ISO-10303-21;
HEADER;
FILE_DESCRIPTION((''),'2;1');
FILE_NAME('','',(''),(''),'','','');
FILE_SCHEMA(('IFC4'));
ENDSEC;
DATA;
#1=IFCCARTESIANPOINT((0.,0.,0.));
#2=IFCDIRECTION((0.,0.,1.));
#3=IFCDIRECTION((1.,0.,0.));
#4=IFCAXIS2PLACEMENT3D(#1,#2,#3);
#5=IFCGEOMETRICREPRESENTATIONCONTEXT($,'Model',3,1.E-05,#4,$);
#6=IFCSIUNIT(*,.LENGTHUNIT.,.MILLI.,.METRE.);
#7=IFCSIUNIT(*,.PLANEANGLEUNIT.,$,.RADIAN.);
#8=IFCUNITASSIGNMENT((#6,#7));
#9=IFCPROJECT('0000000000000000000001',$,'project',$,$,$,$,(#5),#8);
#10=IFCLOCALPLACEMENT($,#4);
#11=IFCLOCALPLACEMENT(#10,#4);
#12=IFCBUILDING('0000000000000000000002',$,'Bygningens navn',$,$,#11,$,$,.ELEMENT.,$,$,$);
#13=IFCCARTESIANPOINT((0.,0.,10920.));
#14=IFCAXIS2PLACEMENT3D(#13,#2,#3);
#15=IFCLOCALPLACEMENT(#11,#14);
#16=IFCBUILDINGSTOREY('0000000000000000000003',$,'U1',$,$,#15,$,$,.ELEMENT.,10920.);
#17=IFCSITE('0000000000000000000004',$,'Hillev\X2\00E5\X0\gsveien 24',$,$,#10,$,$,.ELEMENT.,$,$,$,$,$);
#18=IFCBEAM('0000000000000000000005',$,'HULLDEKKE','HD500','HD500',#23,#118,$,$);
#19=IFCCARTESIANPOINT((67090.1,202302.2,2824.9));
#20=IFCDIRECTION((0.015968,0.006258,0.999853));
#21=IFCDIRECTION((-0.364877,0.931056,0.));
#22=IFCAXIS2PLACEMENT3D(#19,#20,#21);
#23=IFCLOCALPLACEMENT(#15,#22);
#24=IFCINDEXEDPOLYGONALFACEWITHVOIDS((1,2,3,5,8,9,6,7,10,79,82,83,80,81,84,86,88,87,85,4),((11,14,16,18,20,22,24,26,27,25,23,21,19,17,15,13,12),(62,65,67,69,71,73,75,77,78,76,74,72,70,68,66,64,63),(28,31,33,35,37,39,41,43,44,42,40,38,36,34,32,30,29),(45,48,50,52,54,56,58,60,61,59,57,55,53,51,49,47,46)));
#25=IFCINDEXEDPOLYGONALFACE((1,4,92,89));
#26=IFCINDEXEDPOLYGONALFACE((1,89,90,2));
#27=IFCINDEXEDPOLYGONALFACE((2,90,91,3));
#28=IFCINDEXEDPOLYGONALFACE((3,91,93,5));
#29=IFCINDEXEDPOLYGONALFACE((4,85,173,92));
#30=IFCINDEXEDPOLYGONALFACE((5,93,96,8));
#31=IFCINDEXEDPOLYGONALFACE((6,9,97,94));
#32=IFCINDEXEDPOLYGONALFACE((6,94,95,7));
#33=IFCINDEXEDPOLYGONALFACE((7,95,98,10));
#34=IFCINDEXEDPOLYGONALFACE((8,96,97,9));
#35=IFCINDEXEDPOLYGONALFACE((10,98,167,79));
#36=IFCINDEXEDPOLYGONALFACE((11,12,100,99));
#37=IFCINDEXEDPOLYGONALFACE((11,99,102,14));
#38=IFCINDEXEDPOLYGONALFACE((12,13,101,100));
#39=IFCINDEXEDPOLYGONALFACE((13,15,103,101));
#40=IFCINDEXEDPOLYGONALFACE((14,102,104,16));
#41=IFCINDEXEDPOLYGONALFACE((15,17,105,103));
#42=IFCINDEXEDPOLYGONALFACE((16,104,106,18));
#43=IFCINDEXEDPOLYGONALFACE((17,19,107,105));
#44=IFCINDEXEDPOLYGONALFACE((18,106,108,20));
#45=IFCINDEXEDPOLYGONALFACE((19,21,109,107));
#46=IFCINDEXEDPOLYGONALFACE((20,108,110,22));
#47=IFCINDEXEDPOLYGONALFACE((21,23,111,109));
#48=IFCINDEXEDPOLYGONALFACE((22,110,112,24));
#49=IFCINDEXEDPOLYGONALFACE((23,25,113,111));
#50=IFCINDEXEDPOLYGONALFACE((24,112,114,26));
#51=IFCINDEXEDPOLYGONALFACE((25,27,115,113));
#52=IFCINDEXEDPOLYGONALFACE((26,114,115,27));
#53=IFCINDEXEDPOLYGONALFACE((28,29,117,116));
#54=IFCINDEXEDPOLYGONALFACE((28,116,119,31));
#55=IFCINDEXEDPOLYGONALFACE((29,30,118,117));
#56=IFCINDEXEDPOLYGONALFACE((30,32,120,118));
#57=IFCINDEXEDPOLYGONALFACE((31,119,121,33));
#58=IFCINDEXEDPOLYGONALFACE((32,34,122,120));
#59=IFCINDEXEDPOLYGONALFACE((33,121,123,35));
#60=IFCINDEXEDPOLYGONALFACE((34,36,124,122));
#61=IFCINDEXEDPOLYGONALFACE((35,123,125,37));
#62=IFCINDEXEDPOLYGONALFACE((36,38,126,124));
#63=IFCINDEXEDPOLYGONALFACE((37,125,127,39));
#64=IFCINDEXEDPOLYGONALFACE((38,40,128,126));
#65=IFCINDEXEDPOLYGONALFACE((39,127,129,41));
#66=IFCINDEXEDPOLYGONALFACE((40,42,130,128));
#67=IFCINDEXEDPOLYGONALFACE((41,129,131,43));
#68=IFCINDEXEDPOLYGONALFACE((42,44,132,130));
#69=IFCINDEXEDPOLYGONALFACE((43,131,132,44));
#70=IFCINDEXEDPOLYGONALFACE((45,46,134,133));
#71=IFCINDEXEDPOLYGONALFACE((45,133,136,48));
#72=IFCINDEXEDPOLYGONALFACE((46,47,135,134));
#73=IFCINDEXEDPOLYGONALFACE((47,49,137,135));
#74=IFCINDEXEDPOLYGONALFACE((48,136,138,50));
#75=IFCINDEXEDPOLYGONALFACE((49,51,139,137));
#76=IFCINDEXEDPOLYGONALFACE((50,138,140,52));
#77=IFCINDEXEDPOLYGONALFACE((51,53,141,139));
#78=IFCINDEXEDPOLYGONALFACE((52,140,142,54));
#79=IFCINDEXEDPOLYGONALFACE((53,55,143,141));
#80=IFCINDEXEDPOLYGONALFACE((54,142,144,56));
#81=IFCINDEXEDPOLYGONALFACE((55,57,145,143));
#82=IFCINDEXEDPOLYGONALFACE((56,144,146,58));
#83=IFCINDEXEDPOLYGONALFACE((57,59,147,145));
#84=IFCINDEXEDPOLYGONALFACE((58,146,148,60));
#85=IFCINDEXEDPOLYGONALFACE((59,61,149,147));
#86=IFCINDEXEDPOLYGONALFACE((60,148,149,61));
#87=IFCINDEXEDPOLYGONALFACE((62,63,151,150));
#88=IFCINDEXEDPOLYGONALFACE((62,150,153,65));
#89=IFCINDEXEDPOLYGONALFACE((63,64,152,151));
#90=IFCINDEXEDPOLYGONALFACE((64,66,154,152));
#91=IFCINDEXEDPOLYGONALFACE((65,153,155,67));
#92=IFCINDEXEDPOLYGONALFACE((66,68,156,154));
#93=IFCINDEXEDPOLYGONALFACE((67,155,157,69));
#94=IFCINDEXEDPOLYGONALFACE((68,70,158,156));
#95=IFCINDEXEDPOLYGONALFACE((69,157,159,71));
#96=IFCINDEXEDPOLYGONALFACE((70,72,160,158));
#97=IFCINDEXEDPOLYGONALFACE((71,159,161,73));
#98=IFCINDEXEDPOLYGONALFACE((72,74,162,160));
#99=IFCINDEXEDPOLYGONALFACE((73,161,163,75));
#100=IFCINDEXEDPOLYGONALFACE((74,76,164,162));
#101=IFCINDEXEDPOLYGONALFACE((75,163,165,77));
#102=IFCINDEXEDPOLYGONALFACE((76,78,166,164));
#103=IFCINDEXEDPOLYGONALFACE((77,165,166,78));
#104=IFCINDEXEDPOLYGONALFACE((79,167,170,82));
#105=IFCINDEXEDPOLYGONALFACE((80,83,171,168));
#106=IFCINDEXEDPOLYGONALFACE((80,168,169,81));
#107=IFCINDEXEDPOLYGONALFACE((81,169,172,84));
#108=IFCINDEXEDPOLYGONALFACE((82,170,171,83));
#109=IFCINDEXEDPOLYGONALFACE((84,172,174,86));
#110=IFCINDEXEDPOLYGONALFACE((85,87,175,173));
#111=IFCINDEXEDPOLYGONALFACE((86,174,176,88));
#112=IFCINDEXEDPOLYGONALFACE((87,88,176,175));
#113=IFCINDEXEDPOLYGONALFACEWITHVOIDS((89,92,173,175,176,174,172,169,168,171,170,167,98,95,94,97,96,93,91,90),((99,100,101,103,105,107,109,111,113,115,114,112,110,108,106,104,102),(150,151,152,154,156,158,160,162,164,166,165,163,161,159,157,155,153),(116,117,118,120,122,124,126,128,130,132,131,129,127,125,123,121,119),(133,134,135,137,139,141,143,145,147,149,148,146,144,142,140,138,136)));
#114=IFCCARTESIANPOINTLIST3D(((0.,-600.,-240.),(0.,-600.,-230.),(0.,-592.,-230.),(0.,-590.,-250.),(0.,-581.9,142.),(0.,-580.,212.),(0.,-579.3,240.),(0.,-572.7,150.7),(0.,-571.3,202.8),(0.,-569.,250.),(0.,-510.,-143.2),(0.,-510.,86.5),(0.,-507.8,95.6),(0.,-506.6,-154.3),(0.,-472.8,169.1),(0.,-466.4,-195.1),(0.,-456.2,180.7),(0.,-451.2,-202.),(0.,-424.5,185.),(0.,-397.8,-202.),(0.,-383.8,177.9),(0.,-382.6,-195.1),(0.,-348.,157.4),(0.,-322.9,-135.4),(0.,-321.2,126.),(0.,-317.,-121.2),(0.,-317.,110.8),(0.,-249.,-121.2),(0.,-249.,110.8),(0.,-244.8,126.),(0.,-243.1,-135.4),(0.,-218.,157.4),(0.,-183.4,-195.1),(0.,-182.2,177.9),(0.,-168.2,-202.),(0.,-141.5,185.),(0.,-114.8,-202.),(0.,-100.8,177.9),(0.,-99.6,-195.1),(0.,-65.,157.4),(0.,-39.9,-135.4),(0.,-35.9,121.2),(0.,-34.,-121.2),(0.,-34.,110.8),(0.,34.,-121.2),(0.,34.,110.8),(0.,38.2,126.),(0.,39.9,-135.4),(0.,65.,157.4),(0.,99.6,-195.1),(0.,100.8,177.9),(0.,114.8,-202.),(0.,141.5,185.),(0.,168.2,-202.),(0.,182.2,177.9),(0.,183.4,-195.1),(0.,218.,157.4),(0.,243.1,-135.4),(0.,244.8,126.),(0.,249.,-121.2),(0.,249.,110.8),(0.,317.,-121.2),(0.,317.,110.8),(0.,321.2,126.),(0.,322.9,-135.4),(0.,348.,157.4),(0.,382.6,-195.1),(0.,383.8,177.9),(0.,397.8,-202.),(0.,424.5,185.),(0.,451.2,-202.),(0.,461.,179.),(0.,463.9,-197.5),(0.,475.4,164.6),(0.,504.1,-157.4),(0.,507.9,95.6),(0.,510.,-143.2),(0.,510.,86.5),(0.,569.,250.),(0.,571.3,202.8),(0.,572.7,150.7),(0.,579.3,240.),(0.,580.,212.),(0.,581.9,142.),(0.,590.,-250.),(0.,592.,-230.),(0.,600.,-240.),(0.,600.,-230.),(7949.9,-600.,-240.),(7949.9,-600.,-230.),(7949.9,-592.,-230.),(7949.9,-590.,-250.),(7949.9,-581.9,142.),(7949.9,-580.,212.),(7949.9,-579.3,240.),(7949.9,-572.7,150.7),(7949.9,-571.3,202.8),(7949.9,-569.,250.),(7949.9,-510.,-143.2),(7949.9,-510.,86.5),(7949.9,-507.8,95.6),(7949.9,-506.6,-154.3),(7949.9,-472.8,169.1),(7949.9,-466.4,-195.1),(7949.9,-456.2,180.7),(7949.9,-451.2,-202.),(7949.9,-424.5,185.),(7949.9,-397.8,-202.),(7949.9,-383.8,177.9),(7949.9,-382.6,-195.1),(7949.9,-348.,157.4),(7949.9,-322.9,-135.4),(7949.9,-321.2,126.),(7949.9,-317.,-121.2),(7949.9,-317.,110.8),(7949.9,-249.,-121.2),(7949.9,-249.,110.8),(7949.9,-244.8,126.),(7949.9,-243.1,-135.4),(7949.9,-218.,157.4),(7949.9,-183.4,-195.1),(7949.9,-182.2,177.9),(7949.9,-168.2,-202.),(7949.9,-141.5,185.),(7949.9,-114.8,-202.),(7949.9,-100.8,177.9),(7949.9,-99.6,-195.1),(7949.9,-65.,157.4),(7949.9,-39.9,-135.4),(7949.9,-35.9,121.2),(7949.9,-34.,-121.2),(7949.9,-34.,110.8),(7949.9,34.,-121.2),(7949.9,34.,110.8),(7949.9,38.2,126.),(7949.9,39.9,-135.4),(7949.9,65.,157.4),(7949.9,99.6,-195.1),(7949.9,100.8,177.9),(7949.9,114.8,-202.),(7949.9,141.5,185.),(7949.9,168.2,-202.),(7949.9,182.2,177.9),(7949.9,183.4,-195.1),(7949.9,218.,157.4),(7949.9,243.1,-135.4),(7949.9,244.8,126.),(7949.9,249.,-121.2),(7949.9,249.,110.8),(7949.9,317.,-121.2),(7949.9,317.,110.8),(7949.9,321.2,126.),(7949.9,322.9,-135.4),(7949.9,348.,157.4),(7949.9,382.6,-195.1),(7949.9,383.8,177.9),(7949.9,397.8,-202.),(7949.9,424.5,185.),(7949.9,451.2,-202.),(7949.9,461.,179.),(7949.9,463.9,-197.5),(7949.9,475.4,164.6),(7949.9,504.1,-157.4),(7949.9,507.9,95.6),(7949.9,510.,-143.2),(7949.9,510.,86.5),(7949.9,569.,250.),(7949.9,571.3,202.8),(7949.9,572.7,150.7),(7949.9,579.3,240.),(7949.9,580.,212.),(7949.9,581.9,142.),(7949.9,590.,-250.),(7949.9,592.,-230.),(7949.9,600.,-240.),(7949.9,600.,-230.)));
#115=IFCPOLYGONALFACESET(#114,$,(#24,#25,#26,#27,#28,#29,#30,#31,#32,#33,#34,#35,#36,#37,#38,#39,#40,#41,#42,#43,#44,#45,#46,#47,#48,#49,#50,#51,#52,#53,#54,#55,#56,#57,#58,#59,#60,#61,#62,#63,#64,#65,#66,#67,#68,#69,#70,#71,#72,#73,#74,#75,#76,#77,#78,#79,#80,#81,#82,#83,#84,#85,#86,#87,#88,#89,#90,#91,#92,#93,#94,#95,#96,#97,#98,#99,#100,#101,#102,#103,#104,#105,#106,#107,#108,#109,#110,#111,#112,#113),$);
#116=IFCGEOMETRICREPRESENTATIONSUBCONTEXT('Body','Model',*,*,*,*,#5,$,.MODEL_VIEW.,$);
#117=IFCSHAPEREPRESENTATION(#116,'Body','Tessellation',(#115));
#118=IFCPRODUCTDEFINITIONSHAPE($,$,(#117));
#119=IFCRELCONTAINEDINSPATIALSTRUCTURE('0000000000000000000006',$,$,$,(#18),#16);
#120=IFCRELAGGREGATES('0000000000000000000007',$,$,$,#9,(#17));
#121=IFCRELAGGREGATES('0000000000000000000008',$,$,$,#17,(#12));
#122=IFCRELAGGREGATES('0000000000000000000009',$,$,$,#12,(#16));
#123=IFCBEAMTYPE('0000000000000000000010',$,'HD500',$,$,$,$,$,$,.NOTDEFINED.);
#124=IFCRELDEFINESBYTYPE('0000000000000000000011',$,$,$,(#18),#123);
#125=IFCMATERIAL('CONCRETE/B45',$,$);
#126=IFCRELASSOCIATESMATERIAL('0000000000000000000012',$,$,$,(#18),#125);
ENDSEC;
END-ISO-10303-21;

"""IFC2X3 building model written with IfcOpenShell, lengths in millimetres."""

from ifc_helpers import new_model, si_unit, frame, origin_with_axes, place, context, subcontext, project, spatial, polyline, outline, extrude, material, type_object, element, save


model = new_model("IFC2X3")

# Units and contexts
model_context = context("Model", 3, precision=1e-05, world=origin_with_axes())
body_context = subcontext(model_context, "Body", "Model", "MODEL_VIEW")
ifc_project = project(units=[si_unit("LENGTHUNIT", "METRE", prefix="MILLI"), si_unit("PLANEANGLEUNIT", "RADIAN")], contexts=[model_context])

# Site, building, storey
site_placement = place(None, origin_with_axes())
site = spatial("IfcSite", under=ifc_project, at=site_placement, Name="Hillevågsveien 24", CompositionType="ELEMENT")
building_placement = place(site_placement, origin_with_axes())
building = spatial("IfcBuilding", under=site, at=building_placement, Name="Bygningens navn", CompositionType="ELEMENT")
storey_placement = place(building_placement, frame((0.0, 0.0, 10920.0), z_axis=(0.0, 0.0, 1.0), x_axis=(1.0, 0.0, 0.0)))
storey = spatial("IfcBuildingStorey", under=building, at=storey_placement, Name="U1", CompositionType="ELEMENT", Elevation=10920.0)

# Beam
ifc_material_1 = material(Name="CONCRETE/B45")
beam_type_1 = type_object("IfcBeamType", Name="HD500", PredefinedType="NOTDEFINED")
beam_1_placement = place(storey_placement, frame((67090.1, 202302.2, 2824.9), z_axis=(0.015968, 0.006258, 0.999853), x_axis=(-0.364877, 0.931056, 0.0)))
element("IfcBeam", 1, at=beam_1_placement, inside=storey, type_object=beam_type_1, material=ifc_material_1, Name="HULLDEKKE", Description="HD500", ObjectType="HD500", context=body_context, shape_type="SweptSolid", body=[
    extrude(outline(polyline([(581.9, 142.0), (592.0, -230.0), (600.0, -230.0), (600.0, -240.0), (590.0, -250.0), (-590.0, -250.0), (-600.0, -240.0), (-600.0, -230.0), (-592.0, -230.0), (-581.9, 142.0), (-572.7, 150.7), (-571.3, 202.8), (-580.0, 212.0), (-579.3, 240.0), (-569.0, 250.0), (569.0, 250.0), (579.3, 240.0), (580.0, 212.0), (571.3, 202.8), (572.7, 150.7), (581.9, 142.0)]), holes=[polyline([(466.4, -195.1), (506.6, -154.3), (510.0, -143.2), (510.0, 86.5), (507.8, 95.6), (472.8, 169.1), (456.2, 180.7), (424.5, 185.0), (383.8, 177.9), (348.0, 157.4), (321.2, 126.0), (317.0, 110.8), (317.0, -121.2), (322.9, -135.4), (382.6, -195.1), (397.8, -202.0), (451.2, -202.0), (466.4, -195.1)]), polyline([(183.4, -195.1), (243.1, -135.4), (249.0, -121.2), (249.0, 110.8), (244.8, 126.0), (218.0, 157.4), (182.2, 177.9), (141.5, 185.0), (100.8, 177.9), (65.0, 157.4), (35.9, 121.2), (34.0, 110.8), (34.0, -121.2), (39.9, -135.4), (99.6, -195.1), (114.8, -202.0), (168.2, -202.0), (183.4, -195.1)]), polyline([(-99.6, -195.1), (-39.9, -135.4), (-34.0, -121.2), (-34.0, 110.8), (-38.2, 126.0), (-65.0, 157.4), (-100.8, 177.9), (-141.5, 185.0), (-182.2, 177.9), (-218.0, 157.4), (-244.8, 126.0), (-249.0, 110.8), (-249.0, -121.2), (-243.1, -135.4), (-183.4, -195.1), (-168.2, -202.0), (-114.8, -202.0), (-99.6, -195.1)]), polyline([(-382.6, -195.1), (-322.9, -135.4), (-317.0, -121.2), (-317.0, 110.8), (-321.2, 126.0), (-348.0, 157.4), (-383.8, 177.9), (-424.5, 185.0), (-461.0, 179.0), (-475.4, 164.6), (-507.9, 95.6), (-510.0, 86.5), (-510.0, -143.2), (-504.1, -157.4), (-463.9, -197.5), (-451.2, -202.0), (-397.8, -202.0), (-382.6, -195.1)])]), frame((7949.9, 0.0, 0.0), z_axis=(-1.0, 0.0, 0.0), x_axis=(0.0, -1.0, 0.0)), (0.0, 0.0, 1.0), 7949.9),
])

save(model, "model.ifc")
